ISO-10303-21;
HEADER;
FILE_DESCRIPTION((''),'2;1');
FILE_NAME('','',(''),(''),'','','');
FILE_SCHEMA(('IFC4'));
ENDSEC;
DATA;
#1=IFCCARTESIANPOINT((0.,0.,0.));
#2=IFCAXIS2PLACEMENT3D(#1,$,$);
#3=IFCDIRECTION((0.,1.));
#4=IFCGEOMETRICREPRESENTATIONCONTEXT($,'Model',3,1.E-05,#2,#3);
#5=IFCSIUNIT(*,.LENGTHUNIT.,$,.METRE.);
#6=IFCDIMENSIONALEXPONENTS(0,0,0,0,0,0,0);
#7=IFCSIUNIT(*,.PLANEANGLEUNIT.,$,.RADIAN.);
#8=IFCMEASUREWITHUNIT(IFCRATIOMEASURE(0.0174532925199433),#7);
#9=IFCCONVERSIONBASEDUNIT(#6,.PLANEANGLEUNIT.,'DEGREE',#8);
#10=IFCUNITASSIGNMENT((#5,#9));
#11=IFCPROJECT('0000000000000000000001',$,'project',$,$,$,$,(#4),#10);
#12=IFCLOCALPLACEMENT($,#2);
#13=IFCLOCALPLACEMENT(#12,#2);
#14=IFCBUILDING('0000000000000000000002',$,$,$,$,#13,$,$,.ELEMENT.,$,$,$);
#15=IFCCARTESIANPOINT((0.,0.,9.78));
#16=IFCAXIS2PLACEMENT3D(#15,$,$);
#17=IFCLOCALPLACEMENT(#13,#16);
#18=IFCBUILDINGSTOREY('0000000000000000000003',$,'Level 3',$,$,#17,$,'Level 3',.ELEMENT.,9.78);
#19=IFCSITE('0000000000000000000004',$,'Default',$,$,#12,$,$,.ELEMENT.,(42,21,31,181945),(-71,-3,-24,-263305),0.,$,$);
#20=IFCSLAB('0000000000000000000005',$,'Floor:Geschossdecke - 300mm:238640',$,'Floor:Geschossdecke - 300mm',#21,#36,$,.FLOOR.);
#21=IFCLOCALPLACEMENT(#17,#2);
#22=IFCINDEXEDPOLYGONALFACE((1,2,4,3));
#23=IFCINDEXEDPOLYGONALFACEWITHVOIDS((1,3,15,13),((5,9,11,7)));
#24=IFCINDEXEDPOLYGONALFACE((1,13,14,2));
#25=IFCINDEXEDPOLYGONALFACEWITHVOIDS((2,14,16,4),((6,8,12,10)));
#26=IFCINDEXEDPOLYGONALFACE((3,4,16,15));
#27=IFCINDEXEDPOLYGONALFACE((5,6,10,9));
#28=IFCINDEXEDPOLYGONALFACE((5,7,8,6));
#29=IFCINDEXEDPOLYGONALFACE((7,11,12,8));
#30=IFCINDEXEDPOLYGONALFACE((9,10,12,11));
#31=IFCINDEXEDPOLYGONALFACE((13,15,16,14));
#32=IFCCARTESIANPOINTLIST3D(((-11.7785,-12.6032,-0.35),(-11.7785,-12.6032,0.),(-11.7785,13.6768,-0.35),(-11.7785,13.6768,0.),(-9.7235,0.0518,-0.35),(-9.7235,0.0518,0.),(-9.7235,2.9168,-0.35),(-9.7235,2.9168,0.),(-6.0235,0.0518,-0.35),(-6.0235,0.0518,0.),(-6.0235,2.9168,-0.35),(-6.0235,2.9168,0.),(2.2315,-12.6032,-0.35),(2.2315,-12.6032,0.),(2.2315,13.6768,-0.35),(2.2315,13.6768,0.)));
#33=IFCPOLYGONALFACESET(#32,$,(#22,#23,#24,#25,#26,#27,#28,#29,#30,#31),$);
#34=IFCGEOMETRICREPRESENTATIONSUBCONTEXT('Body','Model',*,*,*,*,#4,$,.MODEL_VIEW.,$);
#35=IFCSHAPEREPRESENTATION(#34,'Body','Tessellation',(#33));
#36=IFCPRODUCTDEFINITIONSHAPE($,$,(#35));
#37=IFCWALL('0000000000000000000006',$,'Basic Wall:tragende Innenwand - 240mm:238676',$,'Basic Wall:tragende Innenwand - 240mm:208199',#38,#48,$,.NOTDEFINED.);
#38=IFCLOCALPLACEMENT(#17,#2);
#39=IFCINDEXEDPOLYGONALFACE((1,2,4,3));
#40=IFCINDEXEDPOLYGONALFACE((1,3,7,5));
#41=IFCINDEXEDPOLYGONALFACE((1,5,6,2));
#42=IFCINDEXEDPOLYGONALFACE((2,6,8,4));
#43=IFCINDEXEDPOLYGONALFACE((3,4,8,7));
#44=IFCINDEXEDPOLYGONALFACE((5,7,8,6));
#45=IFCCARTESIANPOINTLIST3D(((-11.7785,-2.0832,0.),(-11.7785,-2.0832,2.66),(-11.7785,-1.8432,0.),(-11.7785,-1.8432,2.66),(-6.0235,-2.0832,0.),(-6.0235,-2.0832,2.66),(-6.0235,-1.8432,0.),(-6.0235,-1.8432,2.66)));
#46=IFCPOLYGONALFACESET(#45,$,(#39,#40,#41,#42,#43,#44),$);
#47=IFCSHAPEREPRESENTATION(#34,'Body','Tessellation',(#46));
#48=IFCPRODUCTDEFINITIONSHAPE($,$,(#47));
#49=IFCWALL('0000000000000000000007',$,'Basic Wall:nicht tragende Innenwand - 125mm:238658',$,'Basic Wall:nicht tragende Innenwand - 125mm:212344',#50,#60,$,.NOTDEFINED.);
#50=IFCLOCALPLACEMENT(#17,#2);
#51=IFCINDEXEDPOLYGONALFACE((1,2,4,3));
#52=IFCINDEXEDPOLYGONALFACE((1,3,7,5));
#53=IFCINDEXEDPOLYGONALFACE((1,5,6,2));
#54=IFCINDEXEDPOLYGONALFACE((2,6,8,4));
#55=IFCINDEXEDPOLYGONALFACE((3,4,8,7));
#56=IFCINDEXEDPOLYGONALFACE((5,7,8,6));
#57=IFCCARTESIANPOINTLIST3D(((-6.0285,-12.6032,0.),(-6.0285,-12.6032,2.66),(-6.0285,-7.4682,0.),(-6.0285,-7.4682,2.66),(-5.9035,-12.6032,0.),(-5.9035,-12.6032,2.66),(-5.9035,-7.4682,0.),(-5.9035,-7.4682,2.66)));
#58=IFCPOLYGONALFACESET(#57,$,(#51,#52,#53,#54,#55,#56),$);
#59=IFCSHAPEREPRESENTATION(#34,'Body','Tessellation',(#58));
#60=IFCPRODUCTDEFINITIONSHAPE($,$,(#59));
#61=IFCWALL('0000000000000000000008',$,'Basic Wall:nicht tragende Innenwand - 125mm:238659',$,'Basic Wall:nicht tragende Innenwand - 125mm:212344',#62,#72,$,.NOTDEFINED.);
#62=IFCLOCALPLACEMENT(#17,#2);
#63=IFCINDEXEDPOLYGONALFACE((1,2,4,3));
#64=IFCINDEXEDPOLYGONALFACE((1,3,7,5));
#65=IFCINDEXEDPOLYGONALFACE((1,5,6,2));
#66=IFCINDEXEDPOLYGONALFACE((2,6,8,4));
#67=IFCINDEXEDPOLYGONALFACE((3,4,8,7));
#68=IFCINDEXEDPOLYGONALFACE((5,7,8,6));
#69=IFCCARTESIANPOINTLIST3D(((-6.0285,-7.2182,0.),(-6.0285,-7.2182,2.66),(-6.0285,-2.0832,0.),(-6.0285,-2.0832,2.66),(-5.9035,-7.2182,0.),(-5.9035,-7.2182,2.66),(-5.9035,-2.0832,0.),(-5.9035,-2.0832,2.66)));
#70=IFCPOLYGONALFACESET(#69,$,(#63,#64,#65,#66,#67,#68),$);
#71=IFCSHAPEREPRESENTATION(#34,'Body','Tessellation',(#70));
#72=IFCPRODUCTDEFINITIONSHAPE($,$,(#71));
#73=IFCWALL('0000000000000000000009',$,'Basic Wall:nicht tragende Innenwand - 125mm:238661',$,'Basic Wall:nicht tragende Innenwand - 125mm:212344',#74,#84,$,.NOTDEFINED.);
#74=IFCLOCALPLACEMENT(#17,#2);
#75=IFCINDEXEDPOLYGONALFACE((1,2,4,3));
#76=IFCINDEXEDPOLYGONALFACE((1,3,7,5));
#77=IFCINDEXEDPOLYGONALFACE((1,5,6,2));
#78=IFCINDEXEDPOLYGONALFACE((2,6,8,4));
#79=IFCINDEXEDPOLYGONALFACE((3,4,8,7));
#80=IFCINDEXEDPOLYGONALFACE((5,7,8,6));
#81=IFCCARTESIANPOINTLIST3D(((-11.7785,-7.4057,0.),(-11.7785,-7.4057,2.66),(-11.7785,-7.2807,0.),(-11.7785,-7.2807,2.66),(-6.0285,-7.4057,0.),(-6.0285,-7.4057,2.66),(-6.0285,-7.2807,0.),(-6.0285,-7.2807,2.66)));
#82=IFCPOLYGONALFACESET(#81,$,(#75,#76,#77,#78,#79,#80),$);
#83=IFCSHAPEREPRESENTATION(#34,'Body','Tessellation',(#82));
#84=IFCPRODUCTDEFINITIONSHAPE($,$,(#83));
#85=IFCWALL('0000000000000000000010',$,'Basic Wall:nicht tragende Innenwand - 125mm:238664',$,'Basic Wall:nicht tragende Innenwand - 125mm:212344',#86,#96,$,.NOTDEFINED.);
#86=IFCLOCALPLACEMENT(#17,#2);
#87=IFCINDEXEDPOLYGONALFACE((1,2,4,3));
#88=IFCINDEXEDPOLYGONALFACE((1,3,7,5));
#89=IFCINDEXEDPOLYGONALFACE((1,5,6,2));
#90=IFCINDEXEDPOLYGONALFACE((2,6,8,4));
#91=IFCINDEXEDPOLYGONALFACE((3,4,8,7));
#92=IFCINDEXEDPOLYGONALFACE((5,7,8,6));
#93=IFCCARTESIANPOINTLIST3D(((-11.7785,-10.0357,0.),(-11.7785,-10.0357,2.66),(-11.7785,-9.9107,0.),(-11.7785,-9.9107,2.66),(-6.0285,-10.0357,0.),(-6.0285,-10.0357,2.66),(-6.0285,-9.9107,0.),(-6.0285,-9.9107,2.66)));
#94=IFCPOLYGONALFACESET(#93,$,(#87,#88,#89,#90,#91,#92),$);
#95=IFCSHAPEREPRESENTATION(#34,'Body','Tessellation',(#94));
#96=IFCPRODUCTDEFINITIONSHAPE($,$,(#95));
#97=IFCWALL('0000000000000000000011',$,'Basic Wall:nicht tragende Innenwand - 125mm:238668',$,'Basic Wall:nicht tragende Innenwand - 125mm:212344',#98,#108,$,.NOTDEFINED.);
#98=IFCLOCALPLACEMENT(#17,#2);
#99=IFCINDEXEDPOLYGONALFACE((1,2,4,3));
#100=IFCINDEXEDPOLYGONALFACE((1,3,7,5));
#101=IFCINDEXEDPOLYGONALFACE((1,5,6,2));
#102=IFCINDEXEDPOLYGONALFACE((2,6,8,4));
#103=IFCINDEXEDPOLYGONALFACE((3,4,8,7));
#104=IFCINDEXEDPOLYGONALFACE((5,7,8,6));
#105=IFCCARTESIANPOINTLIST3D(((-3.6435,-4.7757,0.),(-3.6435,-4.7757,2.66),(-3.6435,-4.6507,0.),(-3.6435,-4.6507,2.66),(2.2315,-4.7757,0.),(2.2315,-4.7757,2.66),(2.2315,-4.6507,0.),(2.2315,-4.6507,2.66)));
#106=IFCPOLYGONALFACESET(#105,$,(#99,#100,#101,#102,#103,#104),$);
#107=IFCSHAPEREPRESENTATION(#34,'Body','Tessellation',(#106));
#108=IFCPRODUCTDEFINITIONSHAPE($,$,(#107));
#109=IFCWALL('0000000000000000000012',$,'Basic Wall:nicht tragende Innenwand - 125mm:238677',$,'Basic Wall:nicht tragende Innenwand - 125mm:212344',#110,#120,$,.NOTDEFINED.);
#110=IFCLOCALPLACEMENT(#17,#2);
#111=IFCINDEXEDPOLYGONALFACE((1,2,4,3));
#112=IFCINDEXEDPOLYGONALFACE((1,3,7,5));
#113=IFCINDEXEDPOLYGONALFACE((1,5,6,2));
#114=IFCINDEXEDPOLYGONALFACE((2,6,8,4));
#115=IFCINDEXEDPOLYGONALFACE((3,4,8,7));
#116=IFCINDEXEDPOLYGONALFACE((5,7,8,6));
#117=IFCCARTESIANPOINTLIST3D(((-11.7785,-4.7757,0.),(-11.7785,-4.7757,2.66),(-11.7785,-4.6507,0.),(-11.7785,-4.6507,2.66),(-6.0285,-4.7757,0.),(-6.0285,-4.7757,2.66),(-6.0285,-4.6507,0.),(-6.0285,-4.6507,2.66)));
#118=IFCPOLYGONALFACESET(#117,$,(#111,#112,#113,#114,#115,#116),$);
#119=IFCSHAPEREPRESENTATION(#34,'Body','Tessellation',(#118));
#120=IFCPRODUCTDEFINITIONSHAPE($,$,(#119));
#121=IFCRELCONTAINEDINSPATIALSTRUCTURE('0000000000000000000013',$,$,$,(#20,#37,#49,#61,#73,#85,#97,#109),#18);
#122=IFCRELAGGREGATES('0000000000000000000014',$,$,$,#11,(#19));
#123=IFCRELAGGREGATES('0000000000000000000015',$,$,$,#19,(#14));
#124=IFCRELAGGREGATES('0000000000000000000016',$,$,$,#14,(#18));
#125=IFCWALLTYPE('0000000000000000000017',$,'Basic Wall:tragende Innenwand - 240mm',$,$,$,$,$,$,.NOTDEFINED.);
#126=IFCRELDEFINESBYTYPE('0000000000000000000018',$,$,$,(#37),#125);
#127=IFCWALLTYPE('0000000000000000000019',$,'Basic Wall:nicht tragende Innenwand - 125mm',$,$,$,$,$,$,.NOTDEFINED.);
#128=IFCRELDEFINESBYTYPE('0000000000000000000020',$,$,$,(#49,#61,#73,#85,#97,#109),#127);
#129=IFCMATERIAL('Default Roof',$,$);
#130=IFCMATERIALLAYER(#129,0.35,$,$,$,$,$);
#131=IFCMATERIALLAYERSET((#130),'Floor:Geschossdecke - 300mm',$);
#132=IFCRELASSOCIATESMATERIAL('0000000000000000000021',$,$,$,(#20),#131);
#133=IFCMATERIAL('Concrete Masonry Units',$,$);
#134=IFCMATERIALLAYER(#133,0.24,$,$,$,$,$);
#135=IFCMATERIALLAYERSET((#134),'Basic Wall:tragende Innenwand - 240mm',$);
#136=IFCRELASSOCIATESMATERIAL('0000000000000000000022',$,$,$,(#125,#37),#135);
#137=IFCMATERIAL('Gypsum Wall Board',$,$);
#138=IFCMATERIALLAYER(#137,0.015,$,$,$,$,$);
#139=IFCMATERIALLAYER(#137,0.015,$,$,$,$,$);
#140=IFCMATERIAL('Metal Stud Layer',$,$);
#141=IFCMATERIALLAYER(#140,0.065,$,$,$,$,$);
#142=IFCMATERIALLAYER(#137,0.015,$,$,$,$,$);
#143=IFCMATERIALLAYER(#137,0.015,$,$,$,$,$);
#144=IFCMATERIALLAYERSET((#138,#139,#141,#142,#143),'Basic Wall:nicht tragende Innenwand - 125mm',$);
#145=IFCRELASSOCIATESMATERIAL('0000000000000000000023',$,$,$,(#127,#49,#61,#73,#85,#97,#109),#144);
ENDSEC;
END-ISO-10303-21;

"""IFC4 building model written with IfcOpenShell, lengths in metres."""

from ifc_helpers import new_model, entity, si_unit, converted_unit, direction, frame, frame_2d, origin, origin_2d_with_axis, place, context, subcontext, project, spatial, rectangle, extrude, material, layer, layer_set, layer_usage, type_object, element, save


model = new_model("IFC4")

# Units and contexts
model_context = context("Model", 3, precision=1e-05, world=origin(), true_north=direction((0.0, 1.0)))
body_context = subcontext(model_context, "Body", "Model", "MODEL_VIEW")
ifc_project = project(units=[si_unit("LENGTHUNIT", "METRE"), converted_unit("PLANEANGLEUNIT", "DEGREE", entity("IfcRatioMeasure", 0.0174532925199433), si_unit("PLANEANGLEUNIT", "RADIAN"), dimensions=[0, 0, 0, 0, 0, 0, 0])], contexts=[model_context])

# Site, building, storey
site_placement = place(None, origin())
site = spatial("IfcSite", under=ifc_project, at=site_placement, Name="Default", CompositionType="ELEMENT", RefLatitude=(42, 21, 31, 181945), RefLongitude=(-71, -3, -24, -263305), RefElevation=0.0)
building_placement = place(site_placement, origin())
building = spatial("IfcBuilding", under=site, at=building_placement, CompositionType="ELEMENT")
storey_placement = place(building_placement, frame((0.0, 0.0, 9.78)))
storey = spatial("IfcBuildingStorey", under=building, at=storey_placement, Name="Level 3", LongName="Level 3", CompositionType="ELEMENT", Elevation=9.78)

# Slab, opening
ifc_material_1 = material(Name="Default Roof")
ifc_layer_1 = layer(ifc_material_1, 0.35)
ifc_layer_set_1 = layer_set([ifc_layer_1], Name="Floor:Geschossdecke - 300mm")
ifc_layer_usage_1 = layer_usage(ifc_layer_set_1, "AXIS3", "POSITIVE", 0.0)
slab_placement = place(storey_placement, frame((-11.7785, -12.6032, -0.35)))
slab = element("IfcSlab", 1, at=slab_placement, inside=storey, material=ifc_layer_usage_1, Name="Floor:Geschossdecke - 300mm:238640", ObjectType="Floor:Geschossdecke - 300mm", PredefinedType="FLOOR", context=body_context, shape_type="SweptSolid", body=[
    extrude(rectangle(XDim=26.28, YDim=14.01, at=frame_2d((0.0, 0.0), x_axis=(0.0, -1.0))), frame((7.005, 13.14, 0.35), z_axis=(0.0, 0.0, -1.0), x_axis=(-1.0, 0.0, 0.0)), (0.0, 0.0, 1.0), 0.35),
])
opening_1_placement = place(slab_placement, frame((3.905, 14.0875, 0.35)))
element("IfcOpeningElement", 2, at=opening_1_placement, cuts=slab, ObjectType="Opening", context=body_context, shape_type="SweptSolid", body=[
    extrude(rectangle(XDim=3.7, YDim=2.865, at=origin_2d_with_axis()), frame((0.0, 0.0, 0.0), z_axis=(0.0, 0.0, -1.0), x_axis=(1.0, 0.0, 0.0)), (0.0, 0.0, 1.0), 0.35),
])

# Walls
ifc_material_2 = material(Name="Concrete Masonry Units")
ifc_layer_2 = layer(ifc_material_2, 0.24)
ifc_layer_set_2 = layer_set([ifc_layer_2], Name="Basic Wall:tragende Innenwand - 240mm")
ifc_layer_usage_2 = layer_usage(ifc_layer_set_2, "AXIS2", "POSITIVE", -0.12)
wall_type_1 = type_object("IfcWallType", Name="Basic Wall:tragende Innenwand - 240mm", PredefinedType="NOTDEFINED", material=ifc_layer_set_2)
wall_1_placement = place(storey_placement, frame((-11.7785, -1.9632, 0.0)))
element("IfcWall", 3, at=wall_1_placement, inside=storey, type_object=wall_type_1, material=ifc_layer_usage_2, Name="Basic Wall:tragende Innenwand - 240mm:238676", ObjectType="Basic Wall:tragende Innenwand - 240mm:208199", PredefinedType="NOTDEFINED", context=body_context, shape_type="SweptSolid", body=[
    extrude(rectangle(XDim=5.755, YDim=0.24, at=frame_2d((2.8775, 0.0), x_axis=(-1.0, 0.0))), origin(), (0.0, 0.0, 1.0), 2.66),
])
ifc_material_3 = material(Name="Gypsum Wall Board")
ifc_layer_3 = layer(ifc_material_3, 0.015)
ifc_layer_4 = layer(ifc_material_3, 0.015)
ifc_material_4 = material(Name="Metal Stud Layer")
ifc_layer_5 = layer(ifc_material_4, 0.065)
ifc_layer_6 = layer(ifc_material_3, 0.015)
ifc_layer_7 = layer(ifc_material_3, 0.015)
ifc_layer_set_3 = layer_set([ifc_layer_3, ifc_layer_4, ifc_layer_5, ifc_layer_6, ifc_layer_7], Name="Basic Wall:nicht tragende Innenwand - 125mm")
ifc_layer_usage_3 = layer_usage(ifc_layer_set_3, "AXIS2", "NEGATIVE", 0.0625)
wall_type_2 = type_object("IfcWallType", Name="Basic Wall:nicht tragende Innenwand - 125mm", PredefinedType="NOTDEFINED", material=ifc_layer_set_3)
wall_2_placement = place(storey_placement, frame((-5.966, -7.4682, 0.0), z_axis=(0.0, 0.0, 1.0), x_axis=(0.0, -1.0, 0.0)))
element("IfcWall", 4, at=wall_2_placement, inside=storey, type_object=wall_type_2, material=ifc_layer_usage_3, Name="Basic Wall:nicht tragende Innenwand - 125mm:238658", ObjectType="Basic Wall:nicht tragende Innenwand - 125mm:212344", PredefinedType="NOTDEFINED", context=body_context, shape_type="SweptSolid", body=[
    extrude(rectangle(XDim=5.135, YDim=0.125, at=frame_2d((2.5675, 0.0), x_axis=(-1.0, 0.0))), origin(), (0.0, 0.0, 1.0), 2.66),
])
ifc_layer_usage_4 = layer_usage(ifc_layer_set_3, "AXIS2", "NEGATIVE", 0.0625)
wall_3_placement = place(storey_placement, frame((-5.966, -2.0832, 0.0), z_axis=(0.0, 0.0, 1.0), x_axis=(0.0, -1.0, 0.0)))
element("IfcWall", 5, at=wall_3_placement, inside=storey, type_object=wall_type_2, material=ifc_layer_usage_4, Name="Basic Wall:nicht tragende Innenwand - 125mm:238659", ObjectType="Basic Wall:nicht tragende Innenwand - 125mm:212344", PredefinedType="NOTDEFINED", context=body_context, shape_type="SweptSolid", body=[
    extrude(rectangle(XDim=5.135, YDim=0.125, at=frame_2d((2.5675, 0.0), x_axis=(-1.0, 0.0))), origin(), (0.0, 0.0, 1.0), 2.66),
])
ifc_layer_usage_5 = layer_usage(ifc_layer_set_3, "AXIS2", "NEGATIVE", 0.0625)
wall_4_placement = place(storey_placement, frame((-11.7785, -7.3432, 0.0)))
element("IfcWall", 6, at=wall_4_placement, inside=storey, type_object=wall_type_2, material=ifc_layer_usage_5, Name="Basic Wall:nicht tragende Innenwand - 125mm:238661", ObjectType="Basic Wall:nicht tragende Innenwand - 125mm:212344", PredefinedType="NOTDEFINED", context=body_context, shape_type="SweptSolid", body=[
    extrude(rectangle(XDim=5.75, YDim=0.125, at=frame_2d((2.875, 0.0), x_axis=(-1.0, 0.0))), origin(), (0.0, 0.0, 1.0), 2.66),
])
ifc_layer_usage_6 = layer_usage(ifc_layer_set_3, "AXIS2", "NEGATIVE", 0.0625)
wall_5_placement = place(storey_placement, frame((-11.7785, -9.9732, 0.0)))
element("IfcWall", 7, at=wall_5_placement, inside=storey, type_object=wall_type_2, material=ifc_layer_usage_6, Name="Basic Wall:nicht tragende Innenwand - 125mm:238664", ObjectType="Basic Wall:nicht tragende Innenwand - 125mm:212344", PredefinedType="NOTDEFINED", context=body_context, shape_type="SweptSolid", body=[
    extrude(rectangle(XDim=5.75, YDim=0.125, at=frame_2d((2.875, 0.0), x_axis=(-1.0, 0.0))), origin(), (0.0, 0.0, 1.0), 2.66),
])
ifc_layer_usage_7 = layer_usage(ifc_layer_set_3, "AXIS2", "POSITIVE", -0.0625)
wall_6_placement = place(storey_placement, frame((-3.6435, -4.7132, 0.0)))
element("IfcWall", 8, at=wall_6_placement, inside=storey, type_object=wall_type_2, material=ifc_layer_usage_7, Name="Basic Wall:nicht tragende Innenwand - 125mm:238668", ObjectType="Basic Wall:nicht tragende Innenwand - 125mm:212344", PredefinedType="NOTDEFINED", context=body_context, shape_type="SweptSolid", body=[
    extrude(rectangle(XDim=5.875, YDim=0.125, at=frame_2d((2.9375, 0.0), x_axis=(-1.0, 0.0))), origin(), (0.0, 0.0, 1.0), 2.66),
])
ifc_layer_usage_8 = layer_usage(ifc_layer_set_3, "AXIS2", "POSITIVE", -0.0625)
wall_7_placement = place(storey_placement, frame((-11.7785, -4.7132, 0.0)))
element("IfcWall", 9, at=wall_7_placement, inside=storey, type_object=wall_type_2, material=ifc_layer_usage_8, Name="Basic Wall:nicht tragende Innenwand - 125mm:238677", ObjectType="Basic Wall:nicht tragende Innenwand - 125mm:212344", PredefinedType="NOTDEFINED", context=body_context, shape_type="SweptSolid", body=[
    extrude(rectangle(XDim=5.75, YDim=0.125, at=frame_2d((2.875, 0.0), x_axis=(-1.0, 0.0))), origin(), (0.0, 0.0, 1.0), 2.66),
])

save(model, "model.ifc")
